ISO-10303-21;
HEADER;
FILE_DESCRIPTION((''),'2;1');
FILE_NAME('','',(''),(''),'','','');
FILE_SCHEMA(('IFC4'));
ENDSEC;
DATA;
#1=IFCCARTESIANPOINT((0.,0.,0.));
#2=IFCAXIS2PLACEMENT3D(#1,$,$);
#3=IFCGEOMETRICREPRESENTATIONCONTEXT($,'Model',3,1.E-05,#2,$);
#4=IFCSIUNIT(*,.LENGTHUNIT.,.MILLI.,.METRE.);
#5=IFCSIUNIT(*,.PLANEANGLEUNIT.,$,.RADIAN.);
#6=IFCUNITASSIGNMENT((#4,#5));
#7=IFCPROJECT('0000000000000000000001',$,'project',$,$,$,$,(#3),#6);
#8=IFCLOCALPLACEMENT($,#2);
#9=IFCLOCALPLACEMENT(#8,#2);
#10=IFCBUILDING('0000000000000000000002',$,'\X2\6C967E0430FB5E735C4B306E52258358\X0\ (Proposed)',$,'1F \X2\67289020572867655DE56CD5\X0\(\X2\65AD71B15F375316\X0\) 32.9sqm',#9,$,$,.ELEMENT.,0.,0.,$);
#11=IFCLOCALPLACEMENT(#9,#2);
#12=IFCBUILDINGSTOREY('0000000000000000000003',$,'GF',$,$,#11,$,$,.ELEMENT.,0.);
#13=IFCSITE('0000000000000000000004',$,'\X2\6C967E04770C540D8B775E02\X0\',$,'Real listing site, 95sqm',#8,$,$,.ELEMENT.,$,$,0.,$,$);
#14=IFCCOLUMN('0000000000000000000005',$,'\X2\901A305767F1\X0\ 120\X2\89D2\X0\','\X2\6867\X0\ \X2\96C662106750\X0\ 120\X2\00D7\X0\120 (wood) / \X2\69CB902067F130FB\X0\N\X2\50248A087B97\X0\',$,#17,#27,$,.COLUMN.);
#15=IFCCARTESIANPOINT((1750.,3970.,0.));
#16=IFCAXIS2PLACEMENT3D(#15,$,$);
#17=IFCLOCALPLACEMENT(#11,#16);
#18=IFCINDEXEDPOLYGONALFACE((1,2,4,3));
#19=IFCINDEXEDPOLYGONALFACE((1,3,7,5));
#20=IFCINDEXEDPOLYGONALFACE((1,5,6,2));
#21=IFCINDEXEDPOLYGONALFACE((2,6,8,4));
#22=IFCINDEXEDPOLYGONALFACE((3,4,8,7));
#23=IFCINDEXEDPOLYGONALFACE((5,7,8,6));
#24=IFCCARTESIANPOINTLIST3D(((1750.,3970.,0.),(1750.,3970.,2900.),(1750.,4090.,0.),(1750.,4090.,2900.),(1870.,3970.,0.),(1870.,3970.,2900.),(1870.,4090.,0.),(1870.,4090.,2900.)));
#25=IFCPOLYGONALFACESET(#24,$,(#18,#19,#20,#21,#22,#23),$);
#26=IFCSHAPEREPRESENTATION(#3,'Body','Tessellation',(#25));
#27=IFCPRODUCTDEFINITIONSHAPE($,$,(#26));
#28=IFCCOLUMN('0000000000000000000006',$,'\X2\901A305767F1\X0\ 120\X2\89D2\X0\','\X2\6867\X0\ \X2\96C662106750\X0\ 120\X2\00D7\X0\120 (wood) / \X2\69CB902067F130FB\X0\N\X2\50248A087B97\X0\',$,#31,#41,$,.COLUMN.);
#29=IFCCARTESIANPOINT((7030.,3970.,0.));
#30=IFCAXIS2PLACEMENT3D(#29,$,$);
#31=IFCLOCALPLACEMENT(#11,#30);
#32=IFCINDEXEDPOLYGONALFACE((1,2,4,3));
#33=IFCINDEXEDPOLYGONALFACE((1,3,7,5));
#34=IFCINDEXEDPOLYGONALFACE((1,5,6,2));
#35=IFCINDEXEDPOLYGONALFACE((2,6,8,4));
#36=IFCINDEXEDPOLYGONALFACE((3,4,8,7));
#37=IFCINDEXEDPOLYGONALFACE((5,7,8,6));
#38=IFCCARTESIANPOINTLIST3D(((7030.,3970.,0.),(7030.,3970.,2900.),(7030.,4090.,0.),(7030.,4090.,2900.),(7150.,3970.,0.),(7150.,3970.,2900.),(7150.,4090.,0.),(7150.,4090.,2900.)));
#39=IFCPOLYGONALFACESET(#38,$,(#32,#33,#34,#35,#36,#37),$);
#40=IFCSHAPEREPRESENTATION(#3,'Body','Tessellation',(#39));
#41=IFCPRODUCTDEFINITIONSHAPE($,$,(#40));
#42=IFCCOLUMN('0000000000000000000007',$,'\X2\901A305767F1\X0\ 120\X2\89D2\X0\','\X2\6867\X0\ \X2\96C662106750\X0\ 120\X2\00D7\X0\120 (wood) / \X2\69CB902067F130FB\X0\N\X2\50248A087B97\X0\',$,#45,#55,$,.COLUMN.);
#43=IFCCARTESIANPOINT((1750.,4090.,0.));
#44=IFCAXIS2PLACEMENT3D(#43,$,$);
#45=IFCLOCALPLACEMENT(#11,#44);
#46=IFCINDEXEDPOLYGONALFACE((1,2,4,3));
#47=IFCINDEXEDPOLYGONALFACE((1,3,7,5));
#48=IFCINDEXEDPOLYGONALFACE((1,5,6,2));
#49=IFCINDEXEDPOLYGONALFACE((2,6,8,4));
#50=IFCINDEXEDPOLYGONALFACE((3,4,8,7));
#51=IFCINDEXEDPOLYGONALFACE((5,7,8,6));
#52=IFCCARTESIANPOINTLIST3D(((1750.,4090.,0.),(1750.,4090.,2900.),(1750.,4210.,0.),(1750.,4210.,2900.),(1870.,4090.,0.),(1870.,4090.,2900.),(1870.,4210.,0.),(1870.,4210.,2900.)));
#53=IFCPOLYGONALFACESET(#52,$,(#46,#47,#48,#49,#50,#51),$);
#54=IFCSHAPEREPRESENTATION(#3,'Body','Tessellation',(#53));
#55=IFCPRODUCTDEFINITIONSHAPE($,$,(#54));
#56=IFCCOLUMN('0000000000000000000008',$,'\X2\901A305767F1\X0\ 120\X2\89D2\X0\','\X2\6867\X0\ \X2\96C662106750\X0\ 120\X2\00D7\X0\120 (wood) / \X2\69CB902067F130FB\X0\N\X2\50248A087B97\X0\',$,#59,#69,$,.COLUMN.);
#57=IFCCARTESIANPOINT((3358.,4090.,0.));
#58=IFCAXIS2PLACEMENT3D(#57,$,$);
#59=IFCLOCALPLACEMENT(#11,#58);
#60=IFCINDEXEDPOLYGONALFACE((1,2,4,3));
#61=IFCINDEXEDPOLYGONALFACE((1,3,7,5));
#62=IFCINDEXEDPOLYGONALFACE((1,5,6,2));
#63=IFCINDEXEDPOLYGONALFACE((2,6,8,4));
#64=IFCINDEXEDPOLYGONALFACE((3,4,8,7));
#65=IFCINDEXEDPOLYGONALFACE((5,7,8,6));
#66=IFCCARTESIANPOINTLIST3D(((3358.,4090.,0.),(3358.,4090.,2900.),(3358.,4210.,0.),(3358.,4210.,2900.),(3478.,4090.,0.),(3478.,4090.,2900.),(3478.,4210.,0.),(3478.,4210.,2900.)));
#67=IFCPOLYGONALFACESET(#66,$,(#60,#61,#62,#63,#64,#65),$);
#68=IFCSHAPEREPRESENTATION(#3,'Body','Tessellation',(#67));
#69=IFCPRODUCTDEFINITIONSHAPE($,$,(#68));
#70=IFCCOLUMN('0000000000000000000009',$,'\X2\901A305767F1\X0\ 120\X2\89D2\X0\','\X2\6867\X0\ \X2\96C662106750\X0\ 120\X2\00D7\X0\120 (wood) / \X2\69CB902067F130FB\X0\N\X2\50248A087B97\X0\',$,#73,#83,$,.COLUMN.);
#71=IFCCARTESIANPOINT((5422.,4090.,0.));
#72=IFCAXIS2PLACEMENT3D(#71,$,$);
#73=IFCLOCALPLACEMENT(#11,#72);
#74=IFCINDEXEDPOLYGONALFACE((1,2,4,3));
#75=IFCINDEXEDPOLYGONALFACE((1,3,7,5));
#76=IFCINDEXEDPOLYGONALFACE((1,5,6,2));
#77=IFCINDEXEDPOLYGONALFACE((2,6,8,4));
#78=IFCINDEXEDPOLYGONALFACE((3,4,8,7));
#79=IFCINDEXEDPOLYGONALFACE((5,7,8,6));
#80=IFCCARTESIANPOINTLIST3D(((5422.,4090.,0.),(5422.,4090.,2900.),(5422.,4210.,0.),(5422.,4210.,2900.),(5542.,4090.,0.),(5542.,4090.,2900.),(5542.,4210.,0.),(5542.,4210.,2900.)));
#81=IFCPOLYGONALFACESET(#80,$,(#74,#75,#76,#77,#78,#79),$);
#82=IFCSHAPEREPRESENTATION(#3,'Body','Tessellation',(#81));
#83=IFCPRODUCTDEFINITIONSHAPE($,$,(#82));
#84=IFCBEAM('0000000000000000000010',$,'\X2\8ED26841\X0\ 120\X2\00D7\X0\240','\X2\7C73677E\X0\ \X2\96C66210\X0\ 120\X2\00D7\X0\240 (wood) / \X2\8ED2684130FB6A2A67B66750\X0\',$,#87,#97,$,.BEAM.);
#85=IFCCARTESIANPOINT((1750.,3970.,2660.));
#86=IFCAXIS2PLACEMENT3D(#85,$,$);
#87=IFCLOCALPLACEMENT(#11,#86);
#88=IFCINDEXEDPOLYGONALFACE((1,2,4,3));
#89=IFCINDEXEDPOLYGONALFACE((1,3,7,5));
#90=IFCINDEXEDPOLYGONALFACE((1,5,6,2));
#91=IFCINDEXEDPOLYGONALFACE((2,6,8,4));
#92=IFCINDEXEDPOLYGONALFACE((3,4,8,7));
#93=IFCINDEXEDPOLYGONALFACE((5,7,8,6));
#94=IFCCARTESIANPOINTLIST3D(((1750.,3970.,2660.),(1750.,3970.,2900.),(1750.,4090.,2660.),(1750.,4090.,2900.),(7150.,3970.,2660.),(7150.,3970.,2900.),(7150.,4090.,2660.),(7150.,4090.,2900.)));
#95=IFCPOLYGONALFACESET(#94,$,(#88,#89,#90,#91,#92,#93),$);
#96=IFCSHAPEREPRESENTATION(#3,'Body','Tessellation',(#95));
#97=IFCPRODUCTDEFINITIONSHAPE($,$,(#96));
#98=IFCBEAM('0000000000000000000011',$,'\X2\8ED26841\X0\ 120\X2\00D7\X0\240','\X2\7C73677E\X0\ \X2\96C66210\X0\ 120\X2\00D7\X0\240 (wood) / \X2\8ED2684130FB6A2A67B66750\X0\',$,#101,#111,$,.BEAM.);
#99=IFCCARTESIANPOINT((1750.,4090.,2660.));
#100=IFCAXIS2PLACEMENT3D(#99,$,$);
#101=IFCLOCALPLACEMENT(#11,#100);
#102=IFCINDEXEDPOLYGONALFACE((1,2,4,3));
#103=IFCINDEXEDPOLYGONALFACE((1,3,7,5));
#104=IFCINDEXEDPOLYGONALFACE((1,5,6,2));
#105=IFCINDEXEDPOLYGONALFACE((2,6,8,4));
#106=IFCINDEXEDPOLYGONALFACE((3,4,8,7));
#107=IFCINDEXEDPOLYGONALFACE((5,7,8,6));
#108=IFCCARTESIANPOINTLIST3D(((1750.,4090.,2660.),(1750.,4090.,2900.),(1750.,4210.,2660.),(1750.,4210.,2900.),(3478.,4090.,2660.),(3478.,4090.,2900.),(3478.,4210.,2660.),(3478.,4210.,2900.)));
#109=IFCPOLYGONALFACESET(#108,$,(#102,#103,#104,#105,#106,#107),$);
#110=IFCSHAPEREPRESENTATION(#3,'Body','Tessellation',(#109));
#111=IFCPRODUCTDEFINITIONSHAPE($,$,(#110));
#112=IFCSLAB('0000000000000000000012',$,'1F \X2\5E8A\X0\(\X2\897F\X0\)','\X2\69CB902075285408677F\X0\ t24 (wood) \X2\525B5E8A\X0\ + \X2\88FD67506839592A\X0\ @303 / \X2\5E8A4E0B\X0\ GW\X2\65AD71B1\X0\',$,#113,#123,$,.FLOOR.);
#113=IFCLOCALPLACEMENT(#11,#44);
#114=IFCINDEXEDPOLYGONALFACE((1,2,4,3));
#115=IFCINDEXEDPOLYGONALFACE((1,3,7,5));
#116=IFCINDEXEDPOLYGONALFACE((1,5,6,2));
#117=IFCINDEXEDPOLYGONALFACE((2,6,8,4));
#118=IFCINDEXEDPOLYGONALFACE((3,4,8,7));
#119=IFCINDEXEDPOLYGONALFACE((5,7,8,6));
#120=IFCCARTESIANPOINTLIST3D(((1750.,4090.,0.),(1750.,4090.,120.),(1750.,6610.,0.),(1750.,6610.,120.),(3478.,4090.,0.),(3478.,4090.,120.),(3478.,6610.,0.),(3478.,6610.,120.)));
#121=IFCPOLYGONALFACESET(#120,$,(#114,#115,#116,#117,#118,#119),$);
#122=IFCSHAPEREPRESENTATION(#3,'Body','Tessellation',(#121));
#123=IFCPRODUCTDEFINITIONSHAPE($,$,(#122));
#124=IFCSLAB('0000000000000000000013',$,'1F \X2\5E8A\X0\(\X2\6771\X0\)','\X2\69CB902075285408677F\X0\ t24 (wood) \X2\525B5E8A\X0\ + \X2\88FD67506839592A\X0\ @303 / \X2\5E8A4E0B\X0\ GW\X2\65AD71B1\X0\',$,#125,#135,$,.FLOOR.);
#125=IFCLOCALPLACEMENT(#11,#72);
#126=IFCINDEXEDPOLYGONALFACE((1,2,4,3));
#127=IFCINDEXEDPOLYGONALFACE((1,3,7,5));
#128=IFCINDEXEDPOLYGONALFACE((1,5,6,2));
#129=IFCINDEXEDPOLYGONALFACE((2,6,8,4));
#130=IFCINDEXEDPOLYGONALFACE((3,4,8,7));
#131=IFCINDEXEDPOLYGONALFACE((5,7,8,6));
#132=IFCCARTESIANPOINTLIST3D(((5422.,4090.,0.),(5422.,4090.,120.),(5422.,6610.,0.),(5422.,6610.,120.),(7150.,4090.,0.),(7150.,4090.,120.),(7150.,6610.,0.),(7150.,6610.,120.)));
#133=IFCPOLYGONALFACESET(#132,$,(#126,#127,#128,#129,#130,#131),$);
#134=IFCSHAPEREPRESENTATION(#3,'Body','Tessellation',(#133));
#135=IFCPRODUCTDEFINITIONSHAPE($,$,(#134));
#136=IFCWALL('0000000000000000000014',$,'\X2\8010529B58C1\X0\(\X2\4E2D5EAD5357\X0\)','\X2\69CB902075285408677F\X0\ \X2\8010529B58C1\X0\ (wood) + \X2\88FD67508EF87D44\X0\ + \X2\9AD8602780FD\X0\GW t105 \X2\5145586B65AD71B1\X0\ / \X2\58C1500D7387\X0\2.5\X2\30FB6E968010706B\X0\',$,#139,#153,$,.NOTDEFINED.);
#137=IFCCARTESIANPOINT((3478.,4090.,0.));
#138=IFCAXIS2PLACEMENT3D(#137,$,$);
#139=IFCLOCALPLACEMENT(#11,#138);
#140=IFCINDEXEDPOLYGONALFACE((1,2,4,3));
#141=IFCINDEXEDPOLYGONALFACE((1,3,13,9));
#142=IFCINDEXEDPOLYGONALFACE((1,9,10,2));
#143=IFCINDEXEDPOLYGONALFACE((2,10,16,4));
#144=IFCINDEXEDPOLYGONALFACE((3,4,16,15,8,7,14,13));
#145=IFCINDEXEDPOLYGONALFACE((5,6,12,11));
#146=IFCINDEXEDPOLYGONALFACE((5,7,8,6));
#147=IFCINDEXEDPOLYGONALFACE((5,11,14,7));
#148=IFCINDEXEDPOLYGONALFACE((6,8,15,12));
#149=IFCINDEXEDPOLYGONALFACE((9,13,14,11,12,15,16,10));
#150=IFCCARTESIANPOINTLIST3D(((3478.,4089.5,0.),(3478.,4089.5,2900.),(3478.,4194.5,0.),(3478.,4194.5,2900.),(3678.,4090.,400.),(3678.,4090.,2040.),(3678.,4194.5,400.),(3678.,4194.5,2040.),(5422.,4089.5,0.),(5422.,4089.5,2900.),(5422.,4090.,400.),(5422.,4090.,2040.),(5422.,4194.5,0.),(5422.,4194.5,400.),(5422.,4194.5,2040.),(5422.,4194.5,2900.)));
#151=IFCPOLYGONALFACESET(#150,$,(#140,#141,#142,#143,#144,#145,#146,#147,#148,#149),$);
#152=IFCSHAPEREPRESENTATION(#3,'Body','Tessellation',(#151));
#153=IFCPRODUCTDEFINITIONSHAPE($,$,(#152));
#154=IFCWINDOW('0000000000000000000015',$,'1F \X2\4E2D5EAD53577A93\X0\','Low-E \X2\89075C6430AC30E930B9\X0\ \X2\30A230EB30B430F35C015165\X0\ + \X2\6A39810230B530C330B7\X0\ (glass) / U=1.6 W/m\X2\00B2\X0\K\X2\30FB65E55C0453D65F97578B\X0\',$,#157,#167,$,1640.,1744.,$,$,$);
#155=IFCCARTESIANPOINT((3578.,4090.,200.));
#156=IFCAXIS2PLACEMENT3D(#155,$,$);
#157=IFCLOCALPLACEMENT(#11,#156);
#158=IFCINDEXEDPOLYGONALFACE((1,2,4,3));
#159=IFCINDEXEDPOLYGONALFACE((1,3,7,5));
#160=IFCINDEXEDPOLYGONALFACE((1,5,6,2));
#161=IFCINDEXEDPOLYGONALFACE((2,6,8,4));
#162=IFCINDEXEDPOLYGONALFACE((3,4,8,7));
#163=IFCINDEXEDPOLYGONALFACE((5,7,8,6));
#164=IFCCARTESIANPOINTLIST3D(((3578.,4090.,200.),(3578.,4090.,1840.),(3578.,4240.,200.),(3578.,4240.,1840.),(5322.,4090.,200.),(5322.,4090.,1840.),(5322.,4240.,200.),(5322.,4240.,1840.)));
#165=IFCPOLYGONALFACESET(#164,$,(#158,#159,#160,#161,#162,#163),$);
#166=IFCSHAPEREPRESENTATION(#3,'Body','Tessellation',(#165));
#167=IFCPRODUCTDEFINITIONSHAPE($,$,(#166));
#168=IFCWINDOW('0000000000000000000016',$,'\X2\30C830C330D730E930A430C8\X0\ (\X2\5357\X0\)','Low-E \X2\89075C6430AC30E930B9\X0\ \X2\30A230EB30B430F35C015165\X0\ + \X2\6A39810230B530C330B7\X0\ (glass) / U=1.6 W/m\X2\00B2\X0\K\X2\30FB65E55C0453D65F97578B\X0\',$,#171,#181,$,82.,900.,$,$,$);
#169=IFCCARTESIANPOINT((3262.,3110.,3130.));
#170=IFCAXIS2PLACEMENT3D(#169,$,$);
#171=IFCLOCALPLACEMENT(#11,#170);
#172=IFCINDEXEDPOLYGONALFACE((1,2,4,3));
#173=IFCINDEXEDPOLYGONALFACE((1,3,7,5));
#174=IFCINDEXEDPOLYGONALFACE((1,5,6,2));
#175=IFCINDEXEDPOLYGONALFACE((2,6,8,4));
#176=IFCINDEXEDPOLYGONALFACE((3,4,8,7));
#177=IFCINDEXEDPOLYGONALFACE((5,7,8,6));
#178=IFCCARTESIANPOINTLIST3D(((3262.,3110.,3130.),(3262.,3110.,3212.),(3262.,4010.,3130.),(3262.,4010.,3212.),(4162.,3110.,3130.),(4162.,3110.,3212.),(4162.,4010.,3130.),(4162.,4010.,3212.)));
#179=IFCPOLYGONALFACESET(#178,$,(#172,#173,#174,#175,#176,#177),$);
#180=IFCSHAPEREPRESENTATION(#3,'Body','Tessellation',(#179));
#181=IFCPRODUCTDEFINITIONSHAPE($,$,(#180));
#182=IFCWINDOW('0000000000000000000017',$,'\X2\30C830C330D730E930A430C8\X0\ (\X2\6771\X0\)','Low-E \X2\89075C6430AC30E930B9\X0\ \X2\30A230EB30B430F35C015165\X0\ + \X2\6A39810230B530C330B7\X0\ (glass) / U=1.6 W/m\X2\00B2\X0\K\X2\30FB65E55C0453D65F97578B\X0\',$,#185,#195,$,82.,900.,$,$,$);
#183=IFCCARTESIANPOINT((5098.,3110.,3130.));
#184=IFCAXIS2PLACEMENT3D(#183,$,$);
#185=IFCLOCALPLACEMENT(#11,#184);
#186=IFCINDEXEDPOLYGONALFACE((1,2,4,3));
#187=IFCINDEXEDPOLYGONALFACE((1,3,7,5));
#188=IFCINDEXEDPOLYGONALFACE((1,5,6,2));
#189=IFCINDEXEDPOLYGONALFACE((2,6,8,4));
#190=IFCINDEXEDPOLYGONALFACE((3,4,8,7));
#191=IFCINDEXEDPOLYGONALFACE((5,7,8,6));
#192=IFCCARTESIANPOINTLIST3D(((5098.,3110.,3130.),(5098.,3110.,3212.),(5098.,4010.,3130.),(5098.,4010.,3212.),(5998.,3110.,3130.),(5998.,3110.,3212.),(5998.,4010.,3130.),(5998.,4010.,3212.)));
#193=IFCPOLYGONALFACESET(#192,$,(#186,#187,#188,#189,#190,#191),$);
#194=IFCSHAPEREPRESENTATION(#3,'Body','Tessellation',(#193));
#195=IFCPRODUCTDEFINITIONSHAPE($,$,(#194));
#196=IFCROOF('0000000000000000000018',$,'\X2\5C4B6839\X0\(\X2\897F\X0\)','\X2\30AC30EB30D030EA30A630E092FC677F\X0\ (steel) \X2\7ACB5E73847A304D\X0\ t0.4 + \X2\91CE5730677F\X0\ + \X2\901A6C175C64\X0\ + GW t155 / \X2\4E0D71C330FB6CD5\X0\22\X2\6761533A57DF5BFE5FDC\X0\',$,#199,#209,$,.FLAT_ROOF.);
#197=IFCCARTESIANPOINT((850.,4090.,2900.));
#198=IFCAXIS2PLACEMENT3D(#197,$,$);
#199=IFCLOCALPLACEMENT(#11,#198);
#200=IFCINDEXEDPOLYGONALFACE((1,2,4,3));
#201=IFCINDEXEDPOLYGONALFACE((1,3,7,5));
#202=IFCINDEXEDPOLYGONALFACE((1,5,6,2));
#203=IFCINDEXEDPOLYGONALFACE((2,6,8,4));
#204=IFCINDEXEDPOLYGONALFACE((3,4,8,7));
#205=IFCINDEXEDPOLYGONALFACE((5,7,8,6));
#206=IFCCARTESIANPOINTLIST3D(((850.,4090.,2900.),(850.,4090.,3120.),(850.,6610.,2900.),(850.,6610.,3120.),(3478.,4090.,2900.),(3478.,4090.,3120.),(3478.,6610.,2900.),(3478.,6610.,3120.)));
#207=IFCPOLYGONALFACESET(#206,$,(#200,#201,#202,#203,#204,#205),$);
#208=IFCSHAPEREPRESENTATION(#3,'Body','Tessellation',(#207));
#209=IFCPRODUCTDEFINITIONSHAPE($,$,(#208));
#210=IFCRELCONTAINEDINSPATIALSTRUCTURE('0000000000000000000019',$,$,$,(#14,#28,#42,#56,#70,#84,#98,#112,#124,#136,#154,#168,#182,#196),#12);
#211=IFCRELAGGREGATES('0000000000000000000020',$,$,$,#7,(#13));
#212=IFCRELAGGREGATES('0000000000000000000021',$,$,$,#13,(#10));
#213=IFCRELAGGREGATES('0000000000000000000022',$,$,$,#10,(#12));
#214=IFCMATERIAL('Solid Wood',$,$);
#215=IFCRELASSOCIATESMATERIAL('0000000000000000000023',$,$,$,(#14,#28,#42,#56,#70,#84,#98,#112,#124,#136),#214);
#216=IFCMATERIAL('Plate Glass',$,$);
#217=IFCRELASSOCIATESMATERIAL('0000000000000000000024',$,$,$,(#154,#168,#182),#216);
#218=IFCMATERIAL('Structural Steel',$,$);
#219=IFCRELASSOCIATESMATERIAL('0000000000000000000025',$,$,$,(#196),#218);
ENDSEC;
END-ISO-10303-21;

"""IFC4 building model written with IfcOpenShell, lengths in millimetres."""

from ifc_helpers import new_model, si_unit, frame, frame_2d, origin, place, context, project, spatial, rectangle, extrude, material, element, fill, save


model = new_model("IFC4")

# Units and contexts
model_context = context("Model", 3, precision=1e-05, world=origin())
ifc_project = project(units=[si_unit("LENGTHUNIT", "METRE", prefix="MILLI"), si_unit("PLANEANGLEUNIT", "RADIAN")], contexts=[model_context])

# Site, building, storey
site_placement = place(None, origin())
site = spatial("IfcSite", under=ifc_project, at=site_placement, Name="沖縄県名護市", ObjectType="Real listing site, 95sqm", CompositionType="ELEMENT", RefElevation=0.0)
building_placement = place(site_placement, origin())
building = spatial("IfcBuilding", under=site, at=building_placement, Name="沖縄・平屋の別荘 (Proposed)", ObjectType="1F 木造在来工法(断熱強化) 32.9sqm", CompositionType="ELEMENT", ElevationOfRefHeight=0.0, ElevationOfTerrain=0.0)
storey_placement = place(building_placement, origin())
storey = spatial("IfcBuildingStorey", under=building, at=storey_placement, Name="GF", CompositionType="ELEMENT", Elevation=0.0)

# Columns
ifc_material_1 = material(Name="Solid Wood")
column_1_placement = place(storey_placement, frame((1750.0, 3970.0, 0.0)))
element("IfcColumn", 1, at=column_1_placement, inside=storey, material=ifc_material_1, Name="通し柱 120角", Description="桧 集成材 120×120 (wood) / 構造柱・N値計算", PredefinedType="COLUMN", context=model_context, shape_type="SweptSolid", body=[
    extrude(rectangle(XDim=120.0, YDim=120.0, at=frame_2d((60.0, 60.0))), frame((1750.0, 3970.0, 0.0)), (0.0, 0.0, 1.0), 2900.0),
])
column_2_placement = place(storey_placement, frame((7030.0, 3970.0, 0.0)))
element("IfcColumn", 2, at=column_2_placement, inside=storey, material=ifc_material_1, Name="通し柱 120角", Description="桧 集成材 120×120 (wood) / 構造柱・N値計算", PredefinedType="COLUMN", context=model_context, shape_type="SweptSolid", body=[
    extrude(rectangle(XDim=120.0, YDim=120.0, at=frame_2d((60.0, 60.0))), frame((7030.0, 3970.0, 0.0)), (0.0, 0.0, 1.0), 2900.0),
])
column_3_placement = place(storey_placement, frame((1750.0, 4090.0, 0.0)))
element("IfcColumn", 3, at=column_3_placement, inside=storey, material=ifc_material_1, Name="通し柱 120角", Description="桧 集成材 120×120 (wood) / 構造柱・N値計算", PredefinedType="COLUMN", context=model_context, shape_type="SweptSolid", body=[
    extrude(rectangle(XDim=120.0, YDim=120.0, at=frame_2d((60.0, 60.0))), frame((1750.0, 4090.0, 0.0)), (0.0, 0.0, 1.0), 2900.0),
])
column_4_placement = place(storey_placement, frame((3358.0, 4090.0, 0.0)))
element("IfcColumn", 4, at=column_4_placement, inside=storey, material=ifc_material_1, Name="通し柱 120角", Description="桧 集成材 120×120 (wood) / 構造柱・N値計算", PredefinedType="COLUMN", context=model_context, shape_type="SweptSolid", body=[
    extrude(rectangle(XDim=120.0, YDim=120.0, at=frame_2d((60.0, 60.0))), frame((3358.0, 4090.0, 0.0)), (0.0, 0.0, 1.0), 2900.0),
])
column_5_placement = place(storey_placement, frame((5422.0, 4090.0, 0.0)))
element("IfcColumn", 5, at=column_5_placement, inside=storey, material=ifc_material_1, Name="通し柱 120角", Description="桧 集成材 120×120 (wood) / 構造柱・N値計算", PredefinedType="COLUMN", context=model_context, shape_type="SweptSolid", body=[
    extrude(rectangle(XDim=120.0, YDim=120.0, at=frame_2d((60.0, 60.0))), frame((5422.0, 4090.0, 0.0)), (0.0, 0.0, 1.0), 2900.0),
])

# Beams
beam_1_placement = place(storey_placement, frame((1750.0, 3970.0, 2660.0)))
element("IfcBeam", 6, at=beam_1_placement, inside=storey, material=ifc_material_1, Name="軒桁 120×240", Description="米松 集成 120×240 (wood) / 軒桁・横架材", PredefinedType="BEAM", context=model_context, shape_type="SweptSolid", body=[
    extrude(rectangle(XDim=5400.0, YDim=120.0, at=frame_2d((2700.0, 60.0))), frame((1750.0, 3970.0, 2660.0)), (0.0, 0.0, 1.0), 240.0),
])
beam_2_placement = place(storey_placement, frame((1750.0, 4090.0, 2660.0)))
element("IfcBeam", 7, at=beam_2_placement, inside=storey, material=ifc_material_1, Name="軒桁 120×240", Description="米松 集成 120×240 (wood) / 軒桁・横架材", PredefinedType="BEAM", context=model_context, shape_type="SweptSolid", body=[
    extrude(rectangle(XDim=1728.0, YDim=120.0, at=frame_2d((864.0, 60.0))), frame((1750.0, 4090.0, 2660.0)), (0.0, 0.0, 1.0), 240.0),
])

# Slabs
slab_1_placement = place(storey_placement, frame((1750.0, 4090.0, 0.0)))
element("IfcSlab", 8, at=slab_1_placement, inside=storey, material=ifc_material_1, Name="1F 床(西)", Description="構造用合板 t24 (wood) 剛床 + 製材根太 @303 / 床下 GW断熱", PredefinedType="FLOOR", context=model_context, shape_type="SweptSolid", body=[
    extrude(rectangle(XDim=1728.0, YDim=2520.0, at=frame_2d((864.0, 1260.0))), frame((1750.0, 4090.0, 0.0)), (0.0, 0.0, 1.0), 120.0),
])
slab_2_placement = place(storey_placement, frame((5422.0, 4090.0, 0.0)))
element("IfcSlab", 9, at=slab_2_placement, inside=storey, material=ifc_material_1, Name="1F 床(東)", Description="構造用合板 t24 (wood) 剛床 + 製材根太 @303 / 床下 GW断熱", PredefinedType="FLOOR", context=model_context, shape_type="SweptSolid", body=[
    extrude(rectangle(XDim=1728.0, YDim=2520.0, at=frame_2d((864.0, 1260.0))), frame((5422.0, 4090.0, 0.0)), (0.0, 0.0, 1.0), 120.0),
])

# Wall, opening, window
wall_1_placement = place(storey_placement, frame((3478.0, 4090.0, 0.0)))
wall_1 = element("IfcWall", 10, at=wall_1_placement, inside=storey, material=ifc_material_1, Name="耐力壁(中庭南)", Description="構造用合板 耐力壁 (wood) + 製材軸組 + 高性能GW t105 充填断熱 / 壁倍率2.5・準耐火", PredefinedType="NOTDEFINED", context=model_context, shape_type="SweptSolid", body=[
    extrude(rectangle(XDim=1944.0, YDim=105.0, at=frame_2d((972.0, 52.0))), frame((3478.0, 4090.0, 0.0)), (0.0, 0.0, 1.0), 2900.0),
])
opening_placement = place(storey_placement, frame((3578.0, 4090.0, 200.0)))
opening = element("IfcOpeningElement", 11, at=opening_placement, cuts=wall_1, PredefinedType="NOTDEFINED", context=model_context, shape_type="SweptSolid", body=[
    extrude(rectangle(XDim=1744.0, YDim=150.0, at=frame_2d((872.0, 75.0))), frame((3578.0, 4090.0, 200.0)), (0.0, 0.0, 1.0), 1640.0),
])
ifc_material_2 = material(Name="Plate Glass")
window_1_placement = place(storey_placement, frame((3578.0, 4090.0, 200.0)))
window_1 = element("IfcWindow", 12, at=window_1_placement, inside=storey, material=ifc_material_2, Name="1F 中庭南窓", Description="Low-E 複層ガラス アルゴン封入 + 樹脂サッシ (glass) / U=1.6 W/m²K・日射取得型", OverallHeight=1640.0, OverallWidth=1744.0, context=model_context, shape_type="SweptSolid", body=[
    extrude(rectangle(XDim=1744.0, YDim=150.0, at=frame_2d((872.0, 75.0))), frame((3578.0, 4090.0, 200.0)), (0.0, 0.0, 1.0), 1640.0),
])
fill(opening, window_1)

# Windows
window_2_placement = place(storey_placement, frame((3262.0, 3110.0, 3130.0)))
element("IfcWindow", 13, at=window_2_placement, inside=storey, material=ifc_material_2, Name="トップライト (南)", Description="Low-E 複層ガラス アルゴン封入 + 樹脂サッシ (glass) / U=1.6 W/m²K・日射取得型", OverallHeight=82.0, OverallWidth=900.0, context=model_context, shape_type="SweptSolid", body=[
    extrude(rectangle(XDim=900.0, YDim=900.0, at=frame_2d((450.0, 450.0))), frame((3262.0, 3110.0, 3130.0)), (0.0, 0.0, 1.0), 82.0),
])
window_3_placement = place(storey_placement, frame((5098.0, 3110.0, 3130.0)))
element("IfcWindow", 14, at=window_3_placement, inside=storey, material=ifc_material_2, Name="トップライト (東)", Description="Low-E 複層ガラス アルゴン封入 + 樹脂サッシ (glass) / U=1.6 W/m²K・日射取得型", OverallHeight=82.0, OverallWidth=900.0, context=model_context, shape_type="SweptSolid", body=[
    extrude(rectangle(XDim=900.0, YDim=900.0, at=frame_2d((450.0, 450.0))), frame((5098.0, 3110.0, 3130.0)), (0.0, 0.0, 1.0), 82.0),
])

# Roof
ifc_material_3 = material(Name="Structural Steel")
roof_1_placement = place(storey_placement, frame((850.0, 4090.0, 2900.0)))
element("IfcRoof", 15, at=roof_1_placement, inside=storey, material=ifc_material_3, Name="屋根(西)", Description="ガルバリウム鋼板 (steel) 立平葺き t0.4 + 野地板 + 通気層 + GW t155 / 不燃・法22条区域対応", PredefinedType="FLAT_ROOF", context=model_context, shape_type="SweptSolid", body=[
    extrude(rectangle(XDim=2628.0, YDim=2520.0, at=frame_2d((1314.0, 1260.0))), frame((850.0, 4090.0, 2900.0)), (0.0, 0.0, 1.0), 220.0),
])

save(model, "model.ifc")
